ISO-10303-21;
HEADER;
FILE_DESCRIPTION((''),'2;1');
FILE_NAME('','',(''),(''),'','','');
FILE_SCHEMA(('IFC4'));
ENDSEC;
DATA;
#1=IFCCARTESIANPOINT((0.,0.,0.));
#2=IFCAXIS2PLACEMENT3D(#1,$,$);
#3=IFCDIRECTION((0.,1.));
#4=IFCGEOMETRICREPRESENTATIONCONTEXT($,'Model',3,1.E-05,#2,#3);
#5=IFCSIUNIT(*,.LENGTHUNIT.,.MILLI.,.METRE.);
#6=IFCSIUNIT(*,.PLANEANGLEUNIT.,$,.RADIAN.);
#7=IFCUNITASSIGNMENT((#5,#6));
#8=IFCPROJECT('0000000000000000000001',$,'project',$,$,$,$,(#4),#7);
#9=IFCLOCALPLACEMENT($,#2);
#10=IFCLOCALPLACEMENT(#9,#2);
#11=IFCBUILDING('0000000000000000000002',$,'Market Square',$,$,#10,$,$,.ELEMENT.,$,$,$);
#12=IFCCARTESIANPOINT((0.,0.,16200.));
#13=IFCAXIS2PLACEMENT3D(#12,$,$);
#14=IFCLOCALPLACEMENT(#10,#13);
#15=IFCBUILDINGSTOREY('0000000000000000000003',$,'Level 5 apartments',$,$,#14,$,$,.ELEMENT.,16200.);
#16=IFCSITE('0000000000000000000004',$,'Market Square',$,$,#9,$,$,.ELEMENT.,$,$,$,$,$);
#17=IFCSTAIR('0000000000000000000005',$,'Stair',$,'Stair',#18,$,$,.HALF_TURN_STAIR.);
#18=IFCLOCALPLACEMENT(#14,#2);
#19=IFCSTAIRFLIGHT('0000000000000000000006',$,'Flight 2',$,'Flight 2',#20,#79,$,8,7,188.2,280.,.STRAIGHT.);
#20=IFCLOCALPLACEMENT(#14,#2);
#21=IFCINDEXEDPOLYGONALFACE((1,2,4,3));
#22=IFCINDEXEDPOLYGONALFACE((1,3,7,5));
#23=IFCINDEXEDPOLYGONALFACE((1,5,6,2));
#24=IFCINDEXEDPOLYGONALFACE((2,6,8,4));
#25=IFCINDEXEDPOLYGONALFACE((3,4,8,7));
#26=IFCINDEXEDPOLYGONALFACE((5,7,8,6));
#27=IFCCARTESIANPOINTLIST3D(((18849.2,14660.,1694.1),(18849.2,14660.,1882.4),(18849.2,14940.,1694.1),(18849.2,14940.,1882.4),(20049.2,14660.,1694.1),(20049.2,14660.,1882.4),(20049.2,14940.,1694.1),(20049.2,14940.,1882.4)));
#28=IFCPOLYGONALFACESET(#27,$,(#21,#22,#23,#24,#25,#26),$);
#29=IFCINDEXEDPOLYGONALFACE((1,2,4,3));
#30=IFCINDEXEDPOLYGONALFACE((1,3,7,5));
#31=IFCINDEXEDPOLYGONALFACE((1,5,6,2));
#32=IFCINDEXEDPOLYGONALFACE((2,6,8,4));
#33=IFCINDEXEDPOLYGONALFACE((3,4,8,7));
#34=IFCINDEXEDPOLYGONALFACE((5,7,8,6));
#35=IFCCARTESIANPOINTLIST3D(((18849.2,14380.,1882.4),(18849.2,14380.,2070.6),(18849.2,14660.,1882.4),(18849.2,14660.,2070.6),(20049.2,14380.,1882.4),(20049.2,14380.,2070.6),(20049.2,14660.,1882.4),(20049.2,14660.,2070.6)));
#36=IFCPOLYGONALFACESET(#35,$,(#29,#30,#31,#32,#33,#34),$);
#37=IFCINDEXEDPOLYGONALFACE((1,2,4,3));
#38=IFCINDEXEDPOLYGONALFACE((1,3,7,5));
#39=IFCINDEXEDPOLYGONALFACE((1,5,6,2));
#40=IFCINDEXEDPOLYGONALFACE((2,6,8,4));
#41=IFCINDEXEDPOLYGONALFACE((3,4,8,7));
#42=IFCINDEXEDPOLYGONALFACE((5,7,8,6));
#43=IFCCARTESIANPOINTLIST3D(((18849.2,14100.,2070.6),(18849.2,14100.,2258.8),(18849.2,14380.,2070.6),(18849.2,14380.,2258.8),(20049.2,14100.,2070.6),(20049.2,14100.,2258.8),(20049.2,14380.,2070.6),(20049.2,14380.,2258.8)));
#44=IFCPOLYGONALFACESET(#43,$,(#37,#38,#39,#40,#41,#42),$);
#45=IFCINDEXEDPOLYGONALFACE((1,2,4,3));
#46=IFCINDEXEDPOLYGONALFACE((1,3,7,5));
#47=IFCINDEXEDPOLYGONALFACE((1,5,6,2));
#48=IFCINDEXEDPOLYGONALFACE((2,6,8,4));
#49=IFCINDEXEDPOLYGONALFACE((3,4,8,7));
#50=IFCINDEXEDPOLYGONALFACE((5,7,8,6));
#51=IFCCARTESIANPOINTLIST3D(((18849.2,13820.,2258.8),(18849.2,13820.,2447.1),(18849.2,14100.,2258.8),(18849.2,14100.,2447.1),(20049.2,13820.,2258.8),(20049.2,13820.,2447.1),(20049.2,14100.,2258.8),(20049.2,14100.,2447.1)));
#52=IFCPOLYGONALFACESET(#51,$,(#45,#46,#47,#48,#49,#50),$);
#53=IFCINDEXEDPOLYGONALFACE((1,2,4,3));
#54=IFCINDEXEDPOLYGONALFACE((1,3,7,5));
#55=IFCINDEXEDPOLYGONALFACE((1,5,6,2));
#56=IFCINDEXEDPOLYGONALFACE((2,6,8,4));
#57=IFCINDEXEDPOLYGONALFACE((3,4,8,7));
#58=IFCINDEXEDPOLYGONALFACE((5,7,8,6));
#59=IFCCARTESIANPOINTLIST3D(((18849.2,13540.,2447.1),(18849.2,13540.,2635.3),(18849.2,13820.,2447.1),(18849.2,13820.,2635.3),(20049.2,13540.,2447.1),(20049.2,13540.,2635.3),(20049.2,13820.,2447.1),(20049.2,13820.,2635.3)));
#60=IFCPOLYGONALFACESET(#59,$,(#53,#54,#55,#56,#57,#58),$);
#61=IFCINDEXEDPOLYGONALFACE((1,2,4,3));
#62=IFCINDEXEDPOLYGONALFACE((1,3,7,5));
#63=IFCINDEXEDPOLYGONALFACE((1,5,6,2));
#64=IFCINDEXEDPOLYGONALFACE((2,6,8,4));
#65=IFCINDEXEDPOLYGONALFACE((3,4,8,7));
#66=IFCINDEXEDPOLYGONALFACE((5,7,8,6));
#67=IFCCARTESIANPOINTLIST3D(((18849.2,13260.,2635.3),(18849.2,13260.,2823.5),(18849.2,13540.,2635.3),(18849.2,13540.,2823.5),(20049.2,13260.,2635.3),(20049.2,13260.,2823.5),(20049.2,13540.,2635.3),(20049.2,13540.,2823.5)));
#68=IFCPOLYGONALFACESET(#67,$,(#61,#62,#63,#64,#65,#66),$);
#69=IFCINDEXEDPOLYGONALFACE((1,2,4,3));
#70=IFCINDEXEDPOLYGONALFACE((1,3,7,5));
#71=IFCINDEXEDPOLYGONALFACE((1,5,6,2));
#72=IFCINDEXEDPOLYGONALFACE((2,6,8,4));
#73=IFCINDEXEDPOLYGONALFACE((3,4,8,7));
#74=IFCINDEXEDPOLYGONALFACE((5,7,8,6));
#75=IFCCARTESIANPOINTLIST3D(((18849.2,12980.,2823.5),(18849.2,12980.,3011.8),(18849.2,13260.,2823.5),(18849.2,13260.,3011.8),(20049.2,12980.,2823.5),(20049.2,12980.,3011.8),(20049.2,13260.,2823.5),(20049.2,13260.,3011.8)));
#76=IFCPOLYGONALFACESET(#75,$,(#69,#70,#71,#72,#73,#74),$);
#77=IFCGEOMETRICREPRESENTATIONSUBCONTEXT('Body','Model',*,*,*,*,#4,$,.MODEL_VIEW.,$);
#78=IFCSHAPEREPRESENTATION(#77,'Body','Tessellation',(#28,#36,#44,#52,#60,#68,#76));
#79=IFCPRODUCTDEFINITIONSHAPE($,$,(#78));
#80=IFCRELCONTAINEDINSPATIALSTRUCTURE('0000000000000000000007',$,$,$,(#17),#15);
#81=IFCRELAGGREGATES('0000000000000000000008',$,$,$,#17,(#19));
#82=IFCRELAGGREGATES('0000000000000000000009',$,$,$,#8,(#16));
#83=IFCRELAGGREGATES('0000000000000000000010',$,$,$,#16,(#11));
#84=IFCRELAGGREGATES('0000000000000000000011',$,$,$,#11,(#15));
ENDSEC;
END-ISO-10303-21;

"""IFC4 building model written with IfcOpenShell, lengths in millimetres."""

from ifc_helpers import new_model, si_unit, direction, frame, origin, origin_with_axes, place, context, subcontext, project, spatial, polyline, outline, extrude, element, aggregate, save


model = new_model("IFC4")

# Units and contexts
model_context = context("Model", 3, precision=1e-05, world=origin(), true_north=direction((0.0, 1.0)))
body_context = subcontext(model_context, "Body", "Model", "MODEL_VIEW")
ifc_project = project(units=[si_unit("LENGTHUNIT", "METRE", prefix="MILLI"), si_unit("PLANEANGLEUNIT", "RADIAN")], contexts=[model_context])

# Site, building, storey
site_placement = place(None, origin())
site = spatial("IfcSite", under=ifc_project, at=site_placement, Name="Market Square", CompositionType="ELEMENT")
building_placement = place(site_placement, origin())
building = spatial("IfcBuilding", under=site, at=building_placement, Name="Market Square", CompositionType="ELEMENT")
storey_placement = place(building_placement, frame((0.0, 0.0, 16200.0)))
storey = spatial("IfcBuildingStorey", under=building, at=storey_placement, Name="Level 5 apartments", CompositionType="ELEMENT", Elevation=16200.0)

# Stair
stair_placement = place(storey_placement, origin_with_axes())
stair = element("IfcStair", 1, at=stair_placement, inside=storey, Name="Stair", ObjectType="Stair", PredefinedType="HALF_TURN_STAIR")

# Stair flight
stair_flight_placement = place(storey_placement, origin_with_axes())
stair_flight = element("IfcStairFlight", 2, at=stair_flight_placement, Name="Flight 2", ObjectType="Flight 2", NumberOfRisers=8, NumberOfTreads=7, PredefinedType="STRAIGHT", RiserHeight=188.2, TreadLength=280.0, context=body_context, shape_type="SweptSolid", body=[
    extrude(outline(polyline([(20049.2, 14660.0), (20049.2, 14940.0), (18849.2, 14940.0), (18849.2, 14660.0), (20049.2, 14660.0)])), frame((0.0, 0.0, 1694.1)), (0.0, 0.0, 1.0), 188.2),
    extrude(outline(polyline([(20049.2, 14380.0), (20049.2, 14660.0), (18849.2, 14660.0), (18849.2, 14380.0), (20049.2, 14380.0)])), frame((0.0, 0.0, 1882.4)), (0.0, 0.0, 1.0), 188.2),
    extrude(outline(polyline([(20049.2, 14100.0), (20049.2, 14380.0), (18849.2, 14380.0), (18849.2, 14100.0), (20049.2, 14100.0)])), frame((0.0, 0.0, 2070.6)), (0.0, 0.0, 1.0), 188.2),
    extrude(outline(polyline([(20049.2, 13820.0), (20049.2, 14100.0), (18849.2, 14100.0), (18849.2, 13820.0), (20049.2, 13820.0)])), frame((0.0, 0.0, 2258.8)), (0.0, 0.0, 1.0), 188.2),
    extrude(outline(polyline([(20049.2, 13540.0), (20049.2, 13820.0), (18849.2, 13820.0), (18849.2, 13540.0), (20049.2, 13540.0)])), frame((0.0, 0.0, 2447.1)), (0.0, 0.0, 1.0), 188.2),
    extrude(outline(polyline([(20049.2, 13260.0), (20049.2, 13540.0), (18849.2, 13540.0), (18849.2, 13260.0), (20049.2, 13260.0)])), frame((0.0, 0.0, 2635.3)), (0.0, 0.0, 1.0), 188.2),
    extrude(outline(polyline([(20049.2, 12980.0), (20049.2, 13260.0), (18849.2, 13260.0), (18849.2, 12980.0), (20049.2, 12980.0)])), frame((0.0, 0.0, 2823.5)), (0.0, 0.0, 1.0), 188.2),
])

aggregate(stair, [stair_flight])

save(model, "model.ifc")
